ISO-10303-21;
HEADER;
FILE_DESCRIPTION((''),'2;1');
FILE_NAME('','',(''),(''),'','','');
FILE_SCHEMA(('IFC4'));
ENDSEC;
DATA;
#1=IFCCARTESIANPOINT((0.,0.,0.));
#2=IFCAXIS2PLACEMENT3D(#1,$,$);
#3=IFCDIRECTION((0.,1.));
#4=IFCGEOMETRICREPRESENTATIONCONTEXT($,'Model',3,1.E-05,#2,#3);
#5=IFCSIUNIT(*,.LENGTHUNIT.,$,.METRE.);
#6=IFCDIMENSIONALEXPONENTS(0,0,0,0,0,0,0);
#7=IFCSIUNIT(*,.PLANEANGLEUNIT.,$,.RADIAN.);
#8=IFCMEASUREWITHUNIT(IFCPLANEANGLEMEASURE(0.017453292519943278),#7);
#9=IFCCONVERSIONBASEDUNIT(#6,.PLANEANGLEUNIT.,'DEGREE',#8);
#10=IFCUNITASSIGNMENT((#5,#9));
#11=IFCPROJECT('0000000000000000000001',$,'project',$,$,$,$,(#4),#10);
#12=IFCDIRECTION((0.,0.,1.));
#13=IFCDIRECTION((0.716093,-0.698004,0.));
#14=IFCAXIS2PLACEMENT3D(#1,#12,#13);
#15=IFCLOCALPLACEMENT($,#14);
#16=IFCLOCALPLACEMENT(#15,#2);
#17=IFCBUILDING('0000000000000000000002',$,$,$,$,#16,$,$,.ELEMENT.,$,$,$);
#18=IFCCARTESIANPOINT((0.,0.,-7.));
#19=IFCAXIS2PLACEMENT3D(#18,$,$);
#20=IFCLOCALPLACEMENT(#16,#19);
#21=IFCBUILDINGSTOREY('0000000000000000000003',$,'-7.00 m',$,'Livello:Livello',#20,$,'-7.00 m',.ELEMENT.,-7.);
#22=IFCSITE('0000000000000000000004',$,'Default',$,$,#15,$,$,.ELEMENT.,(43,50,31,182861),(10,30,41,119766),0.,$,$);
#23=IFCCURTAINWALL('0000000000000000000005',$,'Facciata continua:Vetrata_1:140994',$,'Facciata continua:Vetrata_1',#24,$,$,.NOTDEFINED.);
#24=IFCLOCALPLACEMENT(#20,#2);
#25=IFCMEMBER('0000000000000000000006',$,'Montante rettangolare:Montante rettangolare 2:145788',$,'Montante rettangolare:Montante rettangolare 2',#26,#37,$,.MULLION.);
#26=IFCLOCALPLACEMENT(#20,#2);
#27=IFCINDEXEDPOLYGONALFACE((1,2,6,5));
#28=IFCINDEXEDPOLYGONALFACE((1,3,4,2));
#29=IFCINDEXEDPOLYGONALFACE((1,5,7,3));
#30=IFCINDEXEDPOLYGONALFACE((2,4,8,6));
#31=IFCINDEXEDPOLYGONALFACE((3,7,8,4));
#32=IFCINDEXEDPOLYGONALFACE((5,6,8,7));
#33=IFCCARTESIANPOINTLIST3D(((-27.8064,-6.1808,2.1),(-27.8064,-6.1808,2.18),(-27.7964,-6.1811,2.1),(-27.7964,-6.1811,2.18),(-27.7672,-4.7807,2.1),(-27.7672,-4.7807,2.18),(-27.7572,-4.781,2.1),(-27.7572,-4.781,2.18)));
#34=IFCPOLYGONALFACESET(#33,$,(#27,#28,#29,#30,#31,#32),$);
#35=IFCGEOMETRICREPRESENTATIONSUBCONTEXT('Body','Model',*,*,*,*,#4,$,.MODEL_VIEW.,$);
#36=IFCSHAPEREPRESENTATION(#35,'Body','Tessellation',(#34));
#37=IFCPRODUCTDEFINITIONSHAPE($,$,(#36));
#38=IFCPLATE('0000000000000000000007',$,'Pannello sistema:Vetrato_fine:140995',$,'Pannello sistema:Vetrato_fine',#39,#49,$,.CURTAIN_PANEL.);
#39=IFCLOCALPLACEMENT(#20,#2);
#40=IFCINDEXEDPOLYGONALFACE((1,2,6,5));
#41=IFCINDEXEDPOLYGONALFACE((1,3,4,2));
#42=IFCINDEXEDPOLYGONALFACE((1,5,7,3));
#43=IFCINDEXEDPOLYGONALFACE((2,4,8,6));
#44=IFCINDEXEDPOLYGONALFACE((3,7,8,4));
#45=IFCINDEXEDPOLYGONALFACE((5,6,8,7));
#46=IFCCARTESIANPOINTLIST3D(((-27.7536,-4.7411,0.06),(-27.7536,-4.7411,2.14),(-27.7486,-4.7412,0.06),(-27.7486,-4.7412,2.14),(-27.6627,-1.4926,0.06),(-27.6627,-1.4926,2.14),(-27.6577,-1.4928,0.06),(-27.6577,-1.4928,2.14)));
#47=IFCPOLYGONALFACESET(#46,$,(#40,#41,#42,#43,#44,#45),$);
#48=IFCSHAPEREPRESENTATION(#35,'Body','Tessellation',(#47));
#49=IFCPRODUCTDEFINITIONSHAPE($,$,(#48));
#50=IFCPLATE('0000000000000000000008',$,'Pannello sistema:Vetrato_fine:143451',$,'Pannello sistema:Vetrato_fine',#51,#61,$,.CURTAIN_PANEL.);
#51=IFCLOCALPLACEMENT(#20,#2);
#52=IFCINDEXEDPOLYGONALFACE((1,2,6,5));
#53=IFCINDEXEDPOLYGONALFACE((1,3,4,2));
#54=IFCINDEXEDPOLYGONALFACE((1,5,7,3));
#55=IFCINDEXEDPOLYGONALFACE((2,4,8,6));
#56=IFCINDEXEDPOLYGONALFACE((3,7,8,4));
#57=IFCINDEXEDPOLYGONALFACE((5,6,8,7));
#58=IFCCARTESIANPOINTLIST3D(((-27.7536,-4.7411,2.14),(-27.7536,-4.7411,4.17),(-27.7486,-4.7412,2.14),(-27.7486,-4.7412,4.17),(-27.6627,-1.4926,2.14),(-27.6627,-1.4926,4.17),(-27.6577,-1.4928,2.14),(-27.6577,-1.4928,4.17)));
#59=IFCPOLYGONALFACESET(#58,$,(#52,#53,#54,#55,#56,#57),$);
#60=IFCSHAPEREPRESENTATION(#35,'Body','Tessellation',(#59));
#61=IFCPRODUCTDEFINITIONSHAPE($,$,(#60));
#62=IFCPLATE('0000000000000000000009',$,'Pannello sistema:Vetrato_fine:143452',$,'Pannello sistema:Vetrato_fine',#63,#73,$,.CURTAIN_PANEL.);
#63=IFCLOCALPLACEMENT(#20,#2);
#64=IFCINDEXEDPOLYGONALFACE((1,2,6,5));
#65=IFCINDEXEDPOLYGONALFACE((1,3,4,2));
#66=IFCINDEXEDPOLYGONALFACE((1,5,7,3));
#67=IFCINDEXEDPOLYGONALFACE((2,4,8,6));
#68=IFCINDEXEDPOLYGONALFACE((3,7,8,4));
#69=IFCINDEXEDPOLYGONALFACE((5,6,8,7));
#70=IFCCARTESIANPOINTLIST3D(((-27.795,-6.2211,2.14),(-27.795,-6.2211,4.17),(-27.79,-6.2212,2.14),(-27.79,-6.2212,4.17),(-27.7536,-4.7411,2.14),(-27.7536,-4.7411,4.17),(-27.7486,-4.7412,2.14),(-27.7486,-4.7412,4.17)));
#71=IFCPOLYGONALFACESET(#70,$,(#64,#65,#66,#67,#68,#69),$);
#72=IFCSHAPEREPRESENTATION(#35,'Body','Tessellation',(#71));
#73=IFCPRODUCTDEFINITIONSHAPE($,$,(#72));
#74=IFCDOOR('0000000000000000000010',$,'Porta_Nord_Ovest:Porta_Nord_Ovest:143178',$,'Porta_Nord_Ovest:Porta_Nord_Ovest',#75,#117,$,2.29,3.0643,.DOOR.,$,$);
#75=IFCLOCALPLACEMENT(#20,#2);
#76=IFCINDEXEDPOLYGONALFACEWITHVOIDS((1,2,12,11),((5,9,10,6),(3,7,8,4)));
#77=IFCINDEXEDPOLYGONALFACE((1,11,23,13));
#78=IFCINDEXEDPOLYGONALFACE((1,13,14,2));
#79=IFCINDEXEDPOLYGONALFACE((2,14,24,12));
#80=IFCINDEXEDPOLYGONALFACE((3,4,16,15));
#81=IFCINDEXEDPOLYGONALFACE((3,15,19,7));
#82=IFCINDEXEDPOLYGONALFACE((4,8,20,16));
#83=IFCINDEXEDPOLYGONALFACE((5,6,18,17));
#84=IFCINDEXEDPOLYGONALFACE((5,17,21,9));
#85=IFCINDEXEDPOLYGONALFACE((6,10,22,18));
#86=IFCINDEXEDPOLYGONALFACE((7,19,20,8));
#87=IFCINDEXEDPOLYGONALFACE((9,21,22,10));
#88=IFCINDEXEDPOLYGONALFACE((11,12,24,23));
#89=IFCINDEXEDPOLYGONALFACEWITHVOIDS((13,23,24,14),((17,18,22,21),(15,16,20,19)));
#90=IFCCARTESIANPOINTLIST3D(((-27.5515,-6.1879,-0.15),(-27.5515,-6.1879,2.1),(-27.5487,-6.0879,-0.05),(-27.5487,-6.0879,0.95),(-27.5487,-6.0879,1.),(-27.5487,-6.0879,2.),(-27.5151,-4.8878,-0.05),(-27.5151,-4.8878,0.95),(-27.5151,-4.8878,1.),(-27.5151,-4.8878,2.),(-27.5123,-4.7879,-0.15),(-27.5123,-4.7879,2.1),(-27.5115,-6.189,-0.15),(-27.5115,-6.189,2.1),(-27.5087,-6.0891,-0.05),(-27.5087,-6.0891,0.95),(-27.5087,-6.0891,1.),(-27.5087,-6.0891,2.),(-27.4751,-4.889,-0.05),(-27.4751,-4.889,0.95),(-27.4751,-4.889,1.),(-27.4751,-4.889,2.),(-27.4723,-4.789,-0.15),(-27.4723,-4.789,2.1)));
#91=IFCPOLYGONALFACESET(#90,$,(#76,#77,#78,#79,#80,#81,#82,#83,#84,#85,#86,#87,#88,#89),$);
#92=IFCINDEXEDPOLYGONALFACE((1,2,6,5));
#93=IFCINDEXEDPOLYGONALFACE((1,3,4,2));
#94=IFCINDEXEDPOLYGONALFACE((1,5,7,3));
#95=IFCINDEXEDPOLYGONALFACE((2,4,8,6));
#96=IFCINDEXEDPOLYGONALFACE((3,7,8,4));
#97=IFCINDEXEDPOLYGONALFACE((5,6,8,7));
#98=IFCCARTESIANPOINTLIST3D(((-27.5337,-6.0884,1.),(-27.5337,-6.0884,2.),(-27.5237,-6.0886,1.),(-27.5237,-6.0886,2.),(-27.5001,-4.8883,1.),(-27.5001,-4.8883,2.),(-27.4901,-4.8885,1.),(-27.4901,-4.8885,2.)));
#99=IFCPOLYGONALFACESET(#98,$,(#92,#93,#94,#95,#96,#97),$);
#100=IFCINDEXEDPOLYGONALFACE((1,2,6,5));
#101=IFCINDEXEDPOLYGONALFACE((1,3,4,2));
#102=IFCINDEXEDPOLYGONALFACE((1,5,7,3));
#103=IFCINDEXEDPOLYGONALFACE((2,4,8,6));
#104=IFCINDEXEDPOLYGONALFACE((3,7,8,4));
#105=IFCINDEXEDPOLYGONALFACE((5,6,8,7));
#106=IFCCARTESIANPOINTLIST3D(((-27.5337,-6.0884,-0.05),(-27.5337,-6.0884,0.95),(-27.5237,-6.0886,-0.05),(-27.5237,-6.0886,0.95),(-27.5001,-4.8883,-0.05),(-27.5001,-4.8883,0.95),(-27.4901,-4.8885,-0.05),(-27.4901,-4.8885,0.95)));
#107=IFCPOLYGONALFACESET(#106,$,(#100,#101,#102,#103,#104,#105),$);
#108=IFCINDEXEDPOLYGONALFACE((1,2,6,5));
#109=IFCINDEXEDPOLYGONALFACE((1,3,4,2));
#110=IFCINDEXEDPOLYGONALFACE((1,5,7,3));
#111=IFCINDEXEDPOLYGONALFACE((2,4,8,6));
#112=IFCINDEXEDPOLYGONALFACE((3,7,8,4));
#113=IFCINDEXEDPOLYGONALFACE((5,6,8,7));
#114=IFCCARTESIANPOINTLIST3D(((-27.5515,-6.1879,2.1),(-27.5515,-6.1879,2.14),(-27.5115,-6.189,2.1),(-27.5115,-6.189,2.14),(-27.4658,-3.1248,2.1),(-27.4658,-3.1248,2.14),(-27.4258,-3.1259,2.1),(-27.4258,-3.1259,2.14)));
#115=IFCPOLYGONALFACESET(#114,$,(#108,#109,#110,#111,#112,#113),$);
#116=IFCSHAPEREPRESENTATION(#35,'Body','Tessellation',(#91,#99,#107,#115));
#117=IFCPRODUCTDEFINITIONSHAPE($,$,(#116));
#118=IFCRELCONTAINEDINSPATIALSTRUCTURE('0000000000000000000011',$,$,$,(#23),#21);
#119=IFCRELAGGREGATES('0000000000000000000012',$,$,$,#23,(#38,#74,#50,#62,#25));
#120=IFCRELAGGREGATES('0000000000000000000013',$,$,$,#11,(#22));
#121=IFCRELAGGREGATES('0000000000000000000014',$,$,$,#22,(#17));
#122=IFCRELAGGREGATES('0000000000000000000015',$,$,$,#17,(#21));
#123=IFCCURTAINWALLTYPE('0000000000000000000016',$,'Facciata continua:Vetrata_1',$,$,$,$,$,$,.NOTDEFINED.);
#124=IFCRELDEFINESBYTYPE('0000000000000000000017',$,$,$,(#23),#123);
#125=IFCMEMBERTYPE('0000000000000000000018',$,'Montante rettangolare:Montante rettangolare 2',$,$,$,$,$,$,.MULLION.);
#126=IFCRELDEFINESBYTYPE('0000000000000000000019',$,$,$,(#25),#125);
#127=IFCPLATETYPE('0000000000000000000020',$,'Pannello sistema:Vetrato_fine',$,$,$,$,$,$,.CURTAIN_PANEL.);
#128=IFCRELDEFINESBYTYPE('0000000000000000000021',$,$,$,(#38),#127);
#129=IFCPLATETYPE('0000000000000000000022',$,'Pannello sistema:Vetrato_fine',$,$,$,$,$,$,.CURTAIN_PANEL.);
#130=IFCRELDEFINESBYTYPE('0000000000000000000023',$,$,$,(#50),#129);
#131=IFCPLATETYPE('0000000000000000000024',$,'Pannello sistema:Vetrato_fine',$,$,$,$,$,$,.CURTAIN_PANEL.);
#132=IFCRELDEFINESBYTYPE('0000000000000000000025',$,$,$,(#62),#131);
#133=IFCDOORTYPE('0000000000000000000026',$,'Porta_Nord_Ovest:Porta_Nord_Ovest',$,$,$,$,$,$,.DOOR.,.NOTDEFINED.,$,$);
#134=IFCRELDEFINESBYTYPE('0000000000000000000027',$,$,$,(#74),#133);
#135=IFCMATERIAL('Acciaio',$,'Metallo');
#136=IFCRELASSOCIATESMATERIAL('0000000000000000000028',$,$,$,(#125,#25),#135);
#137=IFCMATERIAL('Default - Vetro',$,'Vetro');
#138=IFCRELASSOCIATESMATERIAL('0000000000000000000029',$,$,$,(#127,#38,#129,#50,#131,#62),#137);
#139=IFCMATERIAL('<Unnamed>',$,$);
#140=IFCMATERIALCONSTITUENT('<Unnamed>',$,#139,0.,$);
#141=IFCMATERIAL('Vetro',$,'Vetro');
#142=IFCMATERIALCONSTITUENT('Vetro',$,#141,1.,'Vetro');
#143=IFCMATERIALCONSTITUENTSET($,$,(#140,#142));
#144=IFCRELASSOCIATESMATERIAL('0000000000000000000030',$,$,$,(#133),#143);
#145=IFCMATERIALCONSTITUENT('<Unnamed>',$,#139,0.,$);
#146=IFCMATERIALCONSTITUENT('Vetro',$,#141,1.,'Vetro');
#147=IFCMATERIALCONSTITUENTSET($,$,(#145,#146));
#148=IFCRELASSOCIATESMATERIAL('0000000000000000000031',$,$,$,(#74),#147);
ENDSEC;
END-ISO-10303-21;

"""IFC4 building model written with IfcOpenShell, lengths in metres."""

from ifc_helpers import new_model, entity, si_unit, converted_unit, direction, frame, origin, place, context, subcontext, project, spatial, indexed_curve, outline, extrude, source, transform, mapped, material, constituent, constituent_set, type_object, type_shapes, element, aggregate, save


model = new_model("IFC4")

# Units and contexts
model_context = context("Model", 3, precision=1e-05, world=origin(), true_north=direction((0.0, 1.0)))
body_context = subcontext(model_context, "Body", "Model", "MODEL_VIEW")
ifc_project = project(units=[si_unit("LENGTHUNIT", "METRE"), converted_unit("PLANEANGLEUNIT", "DEGREE", entity("IfcPlaneAngleMeasure", 0.017453292519943278), si_unit("PLANEANGLEUNIT", "RADIAN"), dimensions=[0, 0, 0, 0, 0, 0, 0])], contexts=[model_context])

# Site, building, storey
site_placement = place(None, frame((0.0, 0.0, 0.0), z_axis=(0.0, 0.0, 1.0), x_axis=(0.716093, -0.698004, 0.0)))
site = spatial("IfcSite", under=ifc_project, at=site_placement, Name="Default", CompositionType="ELEMENT", RefLatitude=(43, 50, 31, 182861), RefLongitude=(10, 30, 41, 119766), RefElevation=0.0)
building_placement = place(site_placement, origin())
building = spatial("IfcBuilding", under=site, at=building_placement, CompositionType="ELEMENT")
storey_placement = place(building_placement, frame((0.0, 0.0, -7.0)))
storey = spatial("IfcBuildingStorey", under=building, at=storey_placement, Name="-7.00 m", ObjectType="Livello:Livello", LongName="-7.00 m", CompositionType="ELEMENT", Elevation=-7.0)

# Curtain wall, member, plates, door
curtain_wall_type = type_object("IfcCurtainWallType", Name="Facciata continua:Vetrata_1", PredefinedType="NOTDEFINED")
curtain_wall_placement = place(storey_placement, frame((0.0, 0.0, 7.0)))
curtain_wall = element("IfcCurtainWall", 1, at=curtain_wall_placement, inside=storey, type_object=curtain_wall_type, Name="Facciata continua:Vetrata_1:140994", ObjectType="Facciata continua:Vetrata_1", PredefinedType="NOTDEFINED")
ifc_material_1 = material(Name="Acciaio", Category="Metallo")
member_type_1 = type_object("IfcMemberType", Name="Montante rettangolare:Montante rettangolare 2", PredefinedType="MULLION", material=ifc_material_1)
shared_shape_1 = source(origin(), body_context, "Body", "SweptSolid", [
    extrude(outline(indexed_curve([(-0.04, -0.005), (0.04, -0.005), (0.04, 0.005), (-0.04, 0.005), (-0.04, -0.005)], self_intersect=False)), frame((0.0, 0.01, -1.4006), z_axis=(0.0, 0.0, 1.0), x_axis=(-1.0, 0.0, 0.0)), (0.0, 0.0, 1.0), 1.4006),
])
type_shapes(member_type_1, [shared_shape_1])
member_1_placement = place(curtain_wall_placement, frame((-27.7914, -6.1812, -4.86), z_axis=(-0.02798, -0.999608, 0.0), x_axis=(0.0, 0.0, 1.0)))
member_1 = element("IfcMember", 2, at=member_1_placement, type_object=member_type_1, material=ifc_material_1, Name="Montante rettangolare:Montante rettangolare 2:145788", ObjectType="Montante rettangolare:Montante rettangolare 2", PredefinedType="MULLION", context=body_context, shape_type="MappedRepresentation", body=[
    mapped(shared_shape_1, transform((0.0, 0.0, 0.0), scale=1.0)),
])
ifc_material_2 = material(Name="Default - Vetro", Category="Vetro")
plate_type_1 = type_object("IfcPlateType", Name="Pannello sistema:Vetrato_fine", PredefinedType="CURTAIN_PANEL", material=ifc_material_2)
shared_shape_2 = source(origin(), body_context, "Body", "SweptSolid", [
    extrude(outline(indexed_curve([(-0.0025, -1.6249), (0.0025, -1.6249), (0.0025, 1.6249), (-0.0025, 1.6249), (-0.0025, -1.6249)], self_intersect=False)), frame((0.0, 0.0, 0.0), z_axis=(0.0, 0.0, 1.0), x_axis=(0.0, 1.0, 0.0)), (0.0, 0.0, 1.0), 2.08),
])
type_shapes(plate_type_1, [shared_shape_2])
plate_1_placement = place(curtain_wall_placement, frame((-27.7056, -3.1169, -6.94), z_axis=(0.0, 0.0, 1.0), x_axis=(-0.02798, -0.999608, 0.0)))
plate_1 = element("IfcPlate", 3, at=plate_1_placement, type_object=plate_type_1, material=ifc_material_2, Name="Pannello sistema:Vetrato_fine:140995", ObjectType="Pannello sistema:Vetrato_fine", PredefinedType="CURTAIN_PANEL", context=body_context, shape_type="MappedRepresentation", body=[
    mapped(shared_shape_2, transform((0.0, 0.0, 0.0), scale=1.0)),
])
plate_type_2 = type_object("IfcPlateType", Name="Pannello sistema:Vetrato_fine", PredefinedType="CURTAIN_PANEL", material=ifc_material_2)
shared_shape_3 = source(origin(), body_context, "Body", "SweptSolid", [
    extrude(outline(indexed_curve([(-0.0025, -1.6249), (0.0025, -1.6249), (0.0025, 1.6249), (-0.0025, 1.6249), (-0.0025, -1.6249)], self_intersect=False)), frame((0.0, 0.0, 0.0), z_axis=(0.0, 0.0, 1.0), x_axis=(0.0, 1.0, 0.0)), (0.0, 0.0, 1.0), 2.03),
])
type_shapes(plate_type_2, [shared_shape_3])
plate_2_placement = place(curtain_wall_placement, frame((-27.7056, -3.1169, -4.86), z_axis=(0.0, 0.0, 1.0), x_axis=(-0.02798, -0.999608, 0.0)))
plate_2 = element("IfcPlate", 4, at=plate_2_placement, type_object=plate_type_2, material=ifc_material_2, Name="Pannello sistema:Vetrato_fine:143451", ObjectType="Pannello sistema:Vetrato_fine", PredefinedType="CURTAIN_PANEL", context=body_context, shape_type="MappedRepresentation", body=[
    mapped(shared_shape_3, transform((0.0, 0.0, 0.0), scale=1.0)),
])
plate_type_3 = type_object("IfcPlateType", Name="Pannello sistema:Vetrato_fine", PredefinedType="CURTAIN_PANEL", material=ifc_material_2)
shared_shape_4 = source(origin(), body_context, "Body", "SweptSolid", [
    extrude(outline(indexed_curve([(-0.0025, -0.7403), (0.0025, -0.7403), (0.0025, 0.7403), (-0.0025, 0.7403), (-0.0025, -0.7403)], self_intersect=False)), frame((0.0, 0.0, 0.0), z_axis=(0.0, 0.0, 1.0), x_axis=(0.0, 1.0, 0.0)), (0.0, 0.0, 1.0), 2.03),
])
type_shapes(plate_type_3, [shared_shape_4])
plate_3_placement = place(curtain_wall_placement, frame((-27.7718, -5.4812, -4.86), z_axis=(0.0, 0.0, 1.0), x_axis=(-0.02798, -0.999608, 0.0)))
plate_3 = element("IfcPlate", 5, at=plate_3_placement, type_object=plate_type_3, material=ifc_material_2, Name="Pannello sistema:Vetrato_fine:143452", ObjectType="Pannello sistema:Vetrato_fine", PredefinedType="CURTAIN_PANEL", context=body_context, shape_type="MappedRepresentation", body=[
    mapped(shared_shape_4, transform((0.0, 0.0, 0.0), scale=1.0)),
])
ifc_material_3 = material(Name="<Unnamed>")
ifc_constituent_1 = constituent(ifc_material_3, Name="<Unnamed>", fraction=0.0)
ifc_material_4 = material(Name="Vetro", Category="Vetro")
ifc_constituent_2 = constituent(ifc_material_4, Name="Vetro", Category="Vetro", fraction=1.0)
ifc_constituent_set_1 = constituent_set(constituents=[ifc_constituent_1, ifc_constituent_2])
ifc_constituent_3 = constituent(ifc_material_3, Name="<Unnamed>", fraction=0.0)
ifc_constituent_4 = constituent(ifc_material_4, Name="Vetro", Category="Vetro", fraction=1.0)
ifc_constituent_set_2 = constituent_set(constituents=[ifc_constituent_3, ifc_constituent_4])
door_type = type_object("IfcDoorType", Name="Porta_Nord_Ovest:Porta_Nord_Ovest", OperationType="NOTDEFINED", PredefinedType="DOOR", material=ifc_constituent_set_2)
shared_shape_5 = source(origin(), body_context, "Body", "SweptSolid", [
    extrude(outline(indexed_curve([(-0.7003, -1.125), (0.7003, -1.125), (0.7003, 1.125), (-0.7003, 1.125), (-0.7003, -1.125)], self_intersect=False), holes=[indexed_curve([(-0.6003, -0.025), (0.6003, -0.025), (0.6003, -1.025), (-0.6003, -1.025), (-0.6003, -0.025)], self_intersect=False), indexed_curve([(-0.6003, 0.025), (-0.6003, 1.025), (0.6003, 1.025), (0.6003, 0.025), (-0.6003, 0.025)], self_intersect=False)]), frame((0.0, -0.24, 0.915), z_axis=(0.0, -1.0, 0.0), x_axis=(-1.0, 0.0, 0.0)), (0.0, 0.0, 1.0), 0.04),
    extrude(outline(indexed_curve([(-0.005, -0.6003), (0.005, -0.6003), (0.005, 0.6003), (-0.005, 0.6003), (-0.005, -0.6003)], self_intersect=False)), frame((0.0, -0.26, 0.94), z_axis=(0.0, 0.0, 1.0), x_axis=(0.0, -1.0, 0.0)), (0.0, 0.0, 1.0), 1.0),
    extrude(outline(indexed_curve([(-0.005, -0.6003), (0.005, -0.6003), (0.005, 0.6003), (-0.005, 0.6003), (-0.005, -0.6003)], self_intersect=False)), frame((0.0, -0.26, -0.11), z_axis=(0.0, 0.0, 1.0), x_axis=(0.0, -1.0, 0.0)), (0.0, 0.0, 1.0), 1.0),
    extrude(outline(indexed_curve([(-0.02, -1.5322), (0.02, -1.5322), (0.02, 1.5322), (-0.02, 1.5322), (-0.02, -1.5322)], self_intersect=False)), frame((0.8319, -0.26, 2.04), z_axis=(0.0, 0.0, 1.0), x_axis=(0.0, -1.0, 0.0)), (0.0, 0.0, 1.0), 0.04),
])
type_shapes(door_type, [shared_shape_5])
door_placement = place(curtain_wall_placement, frame((-27.7718, -5.4812, -6.94), z_axis=(0.0, 0.0, 1.0), x_axis=(0.02798, 0.999608, 0.0)))
door = element("IfcDoor", 6, at=door_placement, type_object=door_type, material=ifc_constituent_set_1, Name="Porta_Nord_Ovest:Porta_Nord_Ovest:143178", ObjectType="Porta_Nord_Ovest:Porta_Nord_Ovest", OverallHeight=2.29, OverallWidth=3.0643, PredefinedType="DOOR", context=body_context, shape_type="MappedRepresentation", body=[
    mapped(shared_shape_5, transform((0.0, 0.0, 0.0), scale=1.0)),
])
aggregate(curtain_wall, [plate_1, door, plate_2, plate_3, member_1])

save(model, "model.ifc")
